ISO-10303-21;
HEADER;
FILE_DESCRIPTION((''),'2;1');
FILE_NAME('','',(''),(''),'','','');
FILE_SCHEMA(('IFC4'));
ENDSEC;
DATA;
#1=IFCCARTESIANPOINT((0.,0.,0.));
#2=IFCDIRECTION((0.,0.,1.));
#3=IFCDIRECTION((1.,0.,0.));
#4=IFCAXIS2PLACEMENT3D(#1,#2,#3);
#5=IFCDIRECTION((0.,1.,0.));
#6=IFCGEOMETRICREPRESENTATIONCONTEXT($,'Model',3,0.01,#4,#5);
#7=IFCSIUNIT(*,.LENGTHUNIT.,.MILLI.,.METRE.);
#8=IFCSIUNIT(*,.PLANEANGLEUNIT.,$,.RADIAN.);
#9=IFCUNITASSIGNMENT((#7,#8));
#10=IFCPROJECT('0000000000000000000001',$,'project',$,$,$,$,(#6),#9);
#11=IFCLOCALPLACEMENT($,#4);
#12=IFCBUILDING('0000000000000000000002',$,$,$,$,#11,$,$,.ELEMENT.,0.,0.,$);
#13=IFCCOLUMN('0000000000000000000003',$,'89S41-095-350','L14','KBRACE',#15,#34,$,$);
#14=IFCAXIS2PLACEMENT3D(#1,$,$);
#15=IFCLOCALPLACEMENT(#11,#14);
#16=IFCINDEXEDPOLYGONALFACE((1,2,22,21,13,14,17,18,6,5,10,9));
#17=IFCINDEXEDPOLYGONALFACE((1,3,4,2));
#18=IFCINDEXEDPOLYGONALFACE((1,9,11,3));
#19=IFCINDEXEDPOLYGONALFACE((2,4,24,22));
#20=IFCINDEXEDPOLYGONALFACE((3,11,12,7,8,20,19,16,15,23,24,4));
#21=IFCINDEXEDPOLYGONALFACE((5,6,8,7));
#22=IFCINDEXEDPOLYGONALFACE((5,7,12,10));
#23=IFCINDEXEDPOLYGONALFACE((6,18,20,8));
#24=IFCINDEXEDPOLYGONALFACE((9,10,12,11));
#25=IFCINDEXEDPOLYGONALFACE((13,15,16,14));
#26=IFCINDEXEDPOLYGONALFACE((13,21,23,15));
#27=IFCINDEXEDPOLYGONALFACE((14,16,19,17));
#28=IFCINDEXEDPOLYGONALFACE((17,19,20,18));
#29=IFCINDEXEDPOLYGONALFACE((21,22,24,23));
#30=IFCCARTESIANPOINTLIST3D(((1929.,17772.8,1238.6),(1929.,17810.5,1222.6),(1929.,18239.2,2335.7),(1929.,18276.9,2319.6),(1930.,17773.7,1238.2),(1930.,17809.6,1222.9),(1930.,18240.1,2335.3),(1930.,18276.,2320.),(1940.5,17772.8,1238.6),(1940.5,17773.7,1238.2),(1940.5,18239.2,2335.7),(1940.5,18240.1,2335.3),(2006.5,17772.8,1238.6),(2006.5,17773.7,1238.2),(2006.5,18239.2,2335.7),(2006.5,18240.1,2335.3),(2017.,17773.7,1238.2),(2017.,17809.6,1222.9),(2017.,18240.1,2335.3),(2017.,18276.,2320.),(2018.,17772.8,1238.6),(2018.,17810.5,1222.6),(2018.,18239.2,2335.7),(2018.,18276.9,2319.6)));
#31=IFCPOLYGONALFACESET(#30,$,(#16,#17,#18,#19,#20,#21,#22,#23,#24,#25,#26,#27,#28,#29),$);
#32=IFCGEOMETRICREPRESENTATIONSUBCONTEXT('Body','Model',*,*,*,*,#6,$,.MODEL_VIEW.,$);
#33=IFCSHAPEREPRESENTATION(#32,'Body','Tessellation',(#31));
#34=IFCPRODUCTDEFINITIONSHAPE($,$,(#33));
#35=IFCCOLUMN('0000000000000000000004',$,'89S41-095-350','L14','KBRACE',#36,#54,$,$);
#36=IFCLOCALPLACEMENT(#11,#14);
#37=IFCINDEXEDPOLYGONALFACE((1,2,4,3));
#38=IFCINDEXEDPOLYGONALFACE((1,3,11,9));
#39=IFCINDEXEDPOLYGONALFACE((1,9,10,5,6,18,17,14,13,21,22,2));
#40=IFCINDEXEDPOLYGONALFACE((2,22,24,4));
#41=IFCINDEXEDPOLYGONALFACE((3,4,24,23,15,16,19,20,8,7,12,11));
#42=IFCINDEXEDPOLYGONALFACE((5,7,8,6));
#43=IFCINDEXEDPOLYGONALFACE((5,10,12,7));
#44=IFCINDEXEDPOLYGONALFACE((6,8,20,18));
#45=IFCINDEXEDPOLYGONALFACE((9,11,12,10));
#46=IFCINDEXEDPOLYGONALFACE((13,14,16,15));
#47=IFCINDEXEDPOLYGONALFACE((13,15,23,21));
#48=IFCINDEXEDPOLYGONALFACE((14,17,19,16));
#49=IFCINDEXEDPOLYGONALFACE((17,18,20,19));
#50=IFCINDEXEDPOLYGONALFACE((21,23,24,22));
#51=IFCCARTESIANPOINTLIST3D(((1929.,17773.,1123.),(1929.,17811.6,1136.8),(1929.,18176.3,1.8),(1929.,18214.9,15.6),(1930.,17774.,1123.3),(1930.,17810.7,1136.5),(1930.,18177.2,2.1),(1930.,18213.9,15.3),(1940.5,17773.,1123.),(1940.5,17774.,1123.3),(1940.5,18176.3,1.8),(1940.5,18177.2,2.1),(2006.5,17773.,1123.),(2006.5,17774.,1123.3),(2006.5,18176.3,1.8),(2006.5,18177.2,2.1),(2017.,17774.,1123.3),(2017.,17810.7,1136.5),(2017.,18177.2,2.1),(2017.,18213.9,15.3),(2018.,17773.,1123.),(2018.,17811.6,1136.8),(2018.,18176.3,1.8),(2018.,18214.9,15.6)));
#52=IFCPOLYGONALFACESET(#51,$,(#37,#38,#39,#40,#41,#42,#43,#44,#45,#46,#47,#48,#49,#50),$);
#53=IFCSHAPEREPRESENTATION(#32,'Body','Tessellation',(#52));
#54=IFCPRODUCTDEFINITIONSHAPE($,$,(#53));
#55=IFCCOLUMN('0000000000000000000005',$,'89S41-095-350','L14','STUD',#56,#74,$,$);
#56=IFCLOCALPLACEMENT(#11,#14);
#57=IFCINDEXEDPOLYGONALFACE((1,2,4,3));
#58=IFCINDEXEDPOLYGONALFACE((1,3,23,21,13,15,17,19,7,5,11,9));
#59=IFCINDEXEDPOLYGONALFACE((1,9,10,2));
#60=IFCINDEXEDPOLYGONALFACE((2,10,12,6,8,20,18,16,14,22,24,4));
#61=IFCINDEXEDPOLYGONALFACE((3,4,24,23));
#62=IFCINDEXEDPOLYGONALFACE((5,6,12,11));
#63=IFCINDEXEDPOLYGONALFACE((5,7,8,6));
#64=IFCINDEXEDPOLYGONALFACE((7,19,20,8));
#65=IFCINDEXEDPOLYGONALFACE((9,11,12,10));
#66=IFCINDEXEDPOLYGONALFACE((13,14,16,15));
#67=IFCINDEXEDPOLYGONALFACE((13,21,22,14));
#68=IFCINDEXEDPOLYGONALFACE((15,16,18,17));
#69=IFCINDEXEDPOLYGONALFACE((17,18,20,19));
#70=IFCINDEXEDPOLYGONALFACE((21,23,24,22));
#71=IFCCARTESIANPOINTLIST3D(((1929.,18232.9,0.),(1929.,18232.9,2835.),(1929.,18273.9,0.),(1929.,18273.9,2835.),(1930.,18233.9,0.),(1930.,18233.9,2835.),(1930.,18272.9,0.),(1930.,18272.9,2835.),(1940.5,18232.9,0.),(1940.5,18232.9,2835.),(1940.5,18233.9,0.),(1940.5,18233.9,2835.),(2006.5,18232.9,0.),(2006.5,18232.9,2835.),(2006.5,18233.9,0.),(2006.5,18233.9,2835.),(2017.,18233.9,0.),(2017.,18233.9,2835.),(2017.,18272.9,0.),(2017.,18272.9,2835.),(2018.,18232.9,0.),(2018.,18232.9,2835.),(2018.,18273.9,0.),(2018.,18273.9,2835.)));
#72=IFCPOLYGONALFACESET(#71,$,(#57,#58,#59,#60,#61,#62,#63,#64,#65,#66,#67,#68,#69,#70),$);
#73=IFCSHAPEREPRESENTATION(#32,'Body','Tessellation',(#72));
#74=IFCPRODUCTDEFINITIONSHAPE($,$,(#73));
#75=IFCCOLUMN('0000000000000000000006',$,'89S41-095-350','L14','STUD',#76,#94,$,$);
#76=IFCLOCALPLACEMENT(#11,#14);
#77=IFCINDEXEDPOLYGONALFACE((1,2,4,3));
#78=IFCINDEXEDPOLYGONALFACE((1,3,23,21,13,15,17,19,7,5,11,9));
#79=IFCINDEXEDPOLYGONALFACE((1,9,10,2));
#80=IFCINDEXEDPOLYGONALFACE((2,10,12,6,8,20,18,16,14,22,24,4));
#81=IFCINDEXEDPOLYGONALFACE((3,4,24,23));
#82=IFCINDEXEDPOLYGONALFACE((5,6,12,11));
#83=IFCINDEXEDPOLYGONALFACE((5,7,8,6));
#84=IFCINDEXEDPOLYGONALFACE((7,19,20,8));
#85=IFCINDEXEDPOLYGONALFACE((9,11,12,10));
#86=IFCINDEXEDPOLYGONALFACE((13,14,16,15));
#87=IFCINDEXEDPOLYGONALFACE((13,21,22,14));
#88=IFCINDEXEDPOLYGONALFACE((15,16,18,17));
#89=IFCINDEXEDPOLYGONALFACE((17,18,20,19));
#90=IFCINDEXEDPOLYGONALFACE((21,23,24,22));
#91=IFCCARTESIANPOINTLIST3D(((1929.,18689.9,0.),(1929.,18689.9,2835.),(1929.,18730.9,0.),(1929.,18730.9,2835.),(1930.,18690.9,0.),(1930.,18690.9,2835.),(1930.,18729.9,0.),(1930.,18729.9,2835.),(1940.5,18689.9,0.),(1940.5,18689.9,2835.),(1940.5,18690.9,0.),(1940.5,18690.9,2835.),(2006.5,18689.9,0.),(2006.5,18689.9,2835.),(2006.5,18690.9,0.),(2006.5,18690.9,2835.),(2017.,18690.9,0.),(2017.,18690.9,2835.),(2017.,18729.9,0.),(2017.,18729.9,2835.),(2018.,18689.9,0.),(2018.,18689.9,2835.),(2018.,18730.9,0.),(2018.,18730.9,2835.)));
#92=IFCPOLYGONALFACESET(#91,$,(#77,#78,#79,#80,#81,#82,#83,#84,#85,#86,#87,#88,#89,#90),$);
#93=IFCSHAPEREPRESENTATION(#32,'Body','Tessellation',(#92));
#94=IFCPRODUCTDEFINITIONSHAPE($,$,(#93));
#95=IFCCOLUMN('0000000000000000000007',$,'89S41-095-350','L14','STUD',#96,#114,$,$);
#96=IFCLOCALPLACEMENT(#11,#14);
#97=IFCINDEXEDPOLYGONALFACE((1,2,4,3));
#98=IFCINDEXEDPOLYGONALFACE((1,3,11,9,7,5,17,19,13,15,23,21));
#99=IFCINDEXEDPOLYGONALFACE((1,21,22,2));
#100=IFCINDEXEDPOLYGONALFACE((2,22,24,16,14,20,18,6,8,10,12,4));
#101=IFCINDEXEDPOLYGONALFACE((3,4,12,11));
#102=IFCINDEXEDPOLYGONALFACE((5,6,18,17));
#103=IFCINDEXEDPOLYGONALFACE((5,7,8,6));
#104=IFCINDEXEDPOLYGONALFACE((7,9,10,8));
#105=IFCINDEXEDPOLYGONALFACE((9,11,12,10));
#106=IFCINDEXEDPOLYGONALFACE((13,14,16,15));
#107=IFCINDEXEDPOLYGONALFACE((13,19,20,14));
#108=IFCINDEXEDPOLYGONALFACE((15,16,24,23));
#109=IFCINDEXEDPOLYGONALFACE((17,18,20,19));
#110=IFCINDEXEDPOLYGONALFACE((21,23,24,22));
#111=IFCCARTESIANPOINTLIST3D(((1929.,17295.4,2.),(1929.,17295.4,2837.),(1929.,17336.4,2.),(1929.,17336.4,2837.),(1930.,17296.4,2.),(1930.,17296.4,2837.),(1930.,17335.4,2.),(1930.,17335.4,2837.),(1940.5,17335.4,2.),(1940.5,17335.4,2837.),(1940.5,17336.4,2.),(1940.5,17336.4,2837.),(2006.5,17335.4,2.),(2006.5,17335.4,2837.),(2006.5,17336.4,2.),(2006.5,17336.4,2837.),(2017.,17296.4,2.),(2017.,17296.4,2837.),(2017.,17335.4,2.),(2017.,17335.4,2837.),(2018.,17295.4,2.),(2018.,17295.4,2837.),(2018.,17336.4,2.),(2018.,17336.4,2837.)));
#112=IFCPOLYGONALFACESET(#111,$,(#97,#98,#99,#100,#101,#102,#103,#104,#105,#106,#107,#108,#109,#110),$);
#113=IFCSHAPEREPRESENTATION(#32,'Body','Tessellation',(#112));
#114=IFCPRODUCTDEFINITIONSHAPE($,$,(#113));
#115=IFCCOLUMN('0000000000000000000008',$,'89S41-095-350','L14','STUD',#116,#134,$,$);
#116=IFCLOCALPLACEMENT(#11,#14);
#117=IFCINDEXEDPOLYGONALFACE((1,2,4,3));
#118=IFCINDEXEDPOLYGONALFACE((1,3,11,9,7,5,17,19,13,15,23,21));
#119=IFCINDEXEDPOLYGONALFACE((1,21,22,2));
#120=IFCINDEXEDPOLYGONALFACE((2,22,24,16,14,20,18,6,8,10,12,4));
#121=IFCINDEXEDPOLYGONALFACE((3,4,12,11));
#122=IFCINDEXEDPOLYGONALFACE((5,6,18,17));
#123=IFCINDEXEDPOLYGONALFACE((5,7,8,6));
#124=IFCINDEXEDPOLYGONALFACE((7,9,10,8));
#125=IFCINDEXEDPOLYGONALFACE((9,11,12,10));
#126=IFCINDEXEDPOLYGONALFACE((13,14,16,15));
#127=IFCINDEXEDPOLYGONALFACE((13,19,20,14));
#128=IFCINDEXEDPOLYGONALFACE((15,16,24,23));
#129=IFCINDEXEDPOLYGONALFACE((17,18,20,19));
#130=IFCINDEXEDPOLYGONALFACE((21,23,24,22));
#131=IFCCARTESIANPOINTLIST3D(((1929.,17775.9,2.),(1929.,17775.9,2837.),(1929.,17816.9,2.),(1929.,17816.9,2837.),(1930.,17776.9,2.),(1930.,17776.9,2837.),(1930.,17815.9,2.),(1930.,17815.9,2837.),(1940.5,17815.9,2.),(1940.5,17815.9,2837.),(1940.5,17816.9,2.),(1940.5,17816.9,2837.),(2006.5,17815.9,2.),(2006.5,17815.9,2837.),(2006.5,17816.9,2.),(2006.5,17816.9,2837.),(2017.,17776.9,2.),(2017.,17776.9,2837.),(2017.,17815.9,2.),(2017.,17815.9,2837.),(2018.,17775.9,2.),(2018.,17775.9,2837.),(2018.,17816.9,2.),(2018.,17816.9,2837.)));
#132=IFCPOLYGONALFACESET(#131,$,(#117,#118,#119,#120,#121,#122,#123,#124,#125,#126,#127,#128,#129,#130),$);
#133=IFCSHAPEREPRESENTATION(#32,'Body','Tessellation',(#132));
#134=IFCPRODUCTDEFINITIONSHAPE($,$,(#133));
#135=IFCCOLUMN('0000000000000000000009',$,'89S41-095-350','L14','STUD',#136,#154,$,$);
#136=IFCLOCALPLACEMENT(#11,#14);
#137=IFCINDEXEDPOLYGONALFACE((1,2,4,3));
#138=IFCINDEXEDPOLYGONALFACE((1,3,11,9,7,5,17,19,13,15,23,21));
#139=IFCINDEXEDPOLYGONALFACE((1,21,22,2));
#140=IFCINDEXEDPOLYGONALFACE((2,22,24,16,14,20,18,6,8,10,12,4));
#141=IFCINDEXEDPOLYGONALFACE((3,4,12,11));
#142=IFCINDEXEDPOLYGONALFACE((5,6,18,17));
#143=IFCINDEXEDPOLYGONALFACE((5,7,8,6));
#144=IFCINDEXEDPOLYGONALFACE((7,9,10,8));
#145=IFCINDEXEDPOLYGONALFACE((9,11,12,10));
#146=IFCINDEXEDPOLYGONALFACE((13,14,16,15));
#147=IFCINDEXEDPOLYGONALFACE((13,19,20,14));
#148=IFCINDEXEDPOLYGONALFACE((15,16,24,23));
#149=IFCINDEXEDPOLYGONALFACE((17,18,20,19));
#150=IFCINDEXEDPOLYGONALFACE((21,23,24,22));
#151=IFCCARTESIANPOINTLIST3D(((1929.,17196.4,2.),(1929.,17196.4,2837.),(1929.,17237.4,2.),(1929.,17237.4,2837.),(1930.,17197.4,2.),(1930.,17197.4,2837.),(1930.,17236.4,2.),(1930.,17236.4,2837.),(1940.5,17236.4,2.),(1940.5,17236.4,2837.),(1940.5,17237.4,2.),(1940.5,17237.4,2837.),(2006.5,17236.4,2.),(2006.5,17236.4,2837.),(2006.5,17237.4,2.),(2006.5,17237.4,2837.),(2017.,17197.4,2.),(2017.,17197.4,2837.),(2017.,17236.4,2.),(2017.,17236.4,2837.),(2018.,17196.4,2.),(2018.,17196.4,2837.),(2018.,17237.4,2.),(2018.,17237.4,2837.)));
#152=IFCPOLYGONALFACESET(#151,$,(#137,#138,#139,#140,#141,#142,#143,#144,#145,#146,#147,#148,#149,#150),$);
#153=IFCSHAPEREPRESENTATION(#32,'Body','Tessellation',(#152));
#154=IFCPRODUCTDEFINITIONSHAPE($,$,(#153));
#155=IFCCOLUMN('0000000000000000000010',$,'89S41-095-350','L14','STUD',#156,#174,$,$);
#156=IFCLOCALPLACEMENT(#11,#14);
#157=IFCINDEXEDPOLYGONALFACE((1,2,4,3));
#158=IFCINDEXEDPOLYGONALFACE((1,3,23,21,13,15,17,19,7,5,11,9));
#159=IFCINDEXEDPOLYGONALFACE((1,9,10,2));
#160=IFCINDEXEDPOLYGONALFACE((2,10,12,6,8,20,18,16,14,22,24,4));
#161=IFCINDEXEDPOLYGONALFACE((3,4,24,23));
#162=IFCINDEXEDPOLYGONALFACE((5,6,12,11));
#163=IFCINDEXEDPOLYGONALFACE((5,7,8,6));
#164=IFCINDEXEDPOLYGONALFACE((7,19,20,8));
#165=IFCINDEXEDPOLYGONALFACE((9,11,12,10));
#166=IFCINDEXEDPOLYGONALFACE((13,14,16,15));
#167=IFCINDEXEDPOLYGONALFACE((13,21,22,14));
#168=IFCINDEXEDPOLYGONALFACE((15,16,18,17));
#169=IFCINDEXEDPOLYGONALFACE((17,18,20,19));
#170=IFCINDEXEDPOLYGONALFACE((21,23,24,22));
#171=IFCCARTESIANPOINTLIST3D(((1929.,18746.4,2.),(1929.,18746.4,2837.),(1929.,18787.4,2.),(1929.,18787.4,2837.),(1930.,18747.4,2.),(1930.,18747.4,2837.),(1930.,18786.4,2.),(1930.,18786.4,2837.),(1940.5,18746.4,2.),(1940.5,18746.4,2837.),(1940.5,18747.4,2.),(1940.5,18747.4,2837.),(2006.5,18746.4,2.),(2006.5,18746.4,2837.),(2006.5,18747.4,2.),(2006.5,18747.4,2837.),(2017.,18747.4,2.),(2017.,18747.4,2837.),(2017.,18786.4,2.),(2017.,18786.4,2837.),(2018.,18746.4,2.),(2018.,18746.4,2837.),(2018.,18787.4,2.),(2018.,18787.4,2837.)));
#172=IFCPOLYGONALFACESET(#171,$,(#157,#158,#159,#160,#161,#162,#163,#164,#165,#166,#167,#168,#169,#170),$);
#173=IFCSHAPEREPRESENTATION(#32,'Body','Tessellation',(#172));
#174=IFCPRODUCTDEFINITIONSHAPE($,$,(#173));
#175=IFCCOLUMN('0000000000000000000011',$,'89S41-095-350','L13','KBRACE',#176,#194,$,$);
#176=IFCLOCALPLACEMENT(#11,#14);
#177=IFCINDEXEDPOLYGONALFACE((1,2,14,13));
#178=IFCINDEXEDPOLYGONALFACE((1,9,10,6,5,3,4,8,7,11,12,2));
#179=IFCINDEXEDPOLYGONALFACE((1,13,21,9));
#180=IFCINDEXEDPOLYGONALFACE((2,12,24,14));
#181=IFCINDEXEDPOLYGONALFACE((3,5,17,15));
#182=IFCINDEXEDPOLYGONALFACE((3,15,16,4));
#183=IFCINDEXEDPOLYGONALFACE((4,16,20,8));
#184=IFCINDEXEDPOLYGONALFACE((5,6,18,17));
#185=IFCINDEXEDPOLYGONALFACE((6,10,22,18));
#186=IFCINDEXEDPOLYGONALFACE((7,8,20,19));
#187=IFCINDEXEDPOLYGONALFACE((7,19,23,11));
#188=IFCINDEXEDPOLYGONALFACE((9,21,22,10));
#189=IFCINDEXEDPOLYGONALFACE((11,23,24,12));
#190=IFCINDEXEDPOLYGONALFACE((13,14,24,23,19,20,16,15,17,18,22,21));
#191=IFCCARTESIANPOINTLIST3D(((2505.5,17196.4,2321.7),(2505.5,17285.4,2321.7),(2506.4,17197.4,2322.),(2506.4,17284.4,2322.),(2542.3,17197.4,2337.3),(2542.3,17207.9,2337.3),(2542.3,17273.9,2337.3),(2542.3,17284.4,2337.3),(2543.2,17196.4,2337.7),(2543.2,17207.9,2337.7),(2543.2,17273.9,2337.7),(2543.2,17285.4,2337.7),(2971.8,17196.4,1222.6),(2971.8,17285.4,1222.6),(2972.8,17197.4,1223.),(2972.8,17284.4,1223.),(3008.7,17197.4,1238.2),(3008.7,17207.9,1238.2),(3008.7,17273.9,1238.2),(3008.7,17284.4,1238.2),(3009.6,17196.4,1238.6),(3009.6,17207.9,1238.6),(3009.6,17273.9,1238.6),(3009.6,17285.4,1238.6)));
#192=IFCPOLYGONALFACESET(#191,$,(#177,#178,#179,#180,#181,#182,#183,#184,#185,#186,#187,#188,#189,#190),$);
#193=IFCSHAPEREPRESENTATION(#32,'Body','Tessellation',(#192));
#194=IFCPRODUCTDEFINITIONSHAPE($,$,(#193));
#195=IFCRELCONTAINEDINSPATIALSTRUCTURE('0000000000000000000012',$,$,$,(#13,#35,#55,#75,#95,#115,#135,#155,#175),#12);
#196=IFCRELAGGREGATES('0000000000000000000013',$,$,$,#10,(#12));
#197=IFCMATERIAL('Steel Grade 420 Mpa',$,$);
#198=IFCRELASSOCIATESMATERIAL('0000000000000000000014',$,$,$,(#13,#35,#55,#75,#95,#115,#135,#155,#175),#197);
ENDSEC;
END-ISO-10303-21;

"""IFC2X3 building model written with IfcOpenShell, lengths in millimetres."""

from ifc_helpers import new_model, si_unit, direction, frame, origin, origin_with_axes, origin_2d_with_axis, place, context, subcontext, project, spatial, c_section, extrude, source, transform, mapped, material, element, save


model = new_model("IFC2X3")

# Units and contexts
model_context = context("Model", 3, precision=0.01, world=origin_with_axes(), true_north=direction((0.0, 1.0, 0.0)))
body_context = subcontext(model_context, "Body", "Model", "MODEL_VIEW")
ifc_project = project(units=[si_unit("LENGTHUNIT", "METRE", prefix="MILLI"), si_unit("PLANEANGLEUNIT", "RADIAN")], contexts=[model_context])

# Building
building_placement = place(None, origin_with_axes())
building = spatial("IfcBuilding", under=ifc_project, at=building_placement, CompositionType="ELEMENT", ElevationOfRefHeight=0.0, ElevationOfTerrain=0.0)

# Columns
ifc_material_1 = material(Name="Steel Grade 420 Mpa")
shared_shape_1 = source(origin(), body_context, "Body", "SweptSolid", [
    extrude(c_section(Depth=89.0, Width=41.0, WallThickness=1.0, Girth=11.5, at=origin_2d_with_axis()), origin_with_axes(), (0.0, 0.0, 1.0), 1192.1),
])
column_1_placement = place(None, frame((1973.5, 17791.7, 1230.6), z_axis=(0.0, 0.391231, 0.920292), x_axis=(0.0, -0.920292, 0.391231)))
element("IfcColumn", 1, at=column_1_placement, inside=building, material=ifc_material_1, Name="89S41-095-350", Description="L14", ObjectType="KBRACE", context=body_context, shape_type="MappedRepresentation", body=[
    mapped(shared_shape_1, transform((0.0, 0.0, 0.0), scale=1.0)),
])
shared_shape_2 = source(origin(), body_context, "Body", "SweptSolid", [
    extrude(c_section(Depth=89.0, Width=41.0, WallThickness=1.0, Girth=11.5, at=origin_2d_with_axis()), origin_with_axes(), (0.0, 0.0, 1.0), 1191.5),
])
column_2_placement = place(None, frame((1973.5, 18195.6, 8.7), z_axis=(0.0, -0.338445, 0.940986), x_axis=(0.0, -0.940986, -0.338445)))
element("IfcColumn", 2, at=column_2_placement, inside=building, material=ifc_material_1, Name="89S41-095-350", Description="L14", ObjectType="KBRACE", context=body_context, shape_type="MappedRepresentation", body=[
    mapped(shared_shape_2, transform((0.0, 0.0, 0.0), scale=1.0)),
])
shared_shape_3 = source(origin(), body_context, "Body", "SweptSolid", [
    extrude(c_section(Depth=89.0, Width=41.0, WallThickness=1.0, Girth=11.5, at=origin_2d_with_axis()), origin_with_axes(), (0.0, 0.0, 1.0), 2835.0),
])
column_3_placement = place(None, frame((1973.5, 18253.4, 0.0), z_axis=(0.0, 0.0, 1.0), x_axis=(0.0, -1.0, 0.0)))
element("IfcColumn", 3, at=column_3_placement, inside=building, material=ifc_material_1, Name="89S41-095-350", Description="L14", ObjectType="STUD", context=body_context, shape_type="MappedRepresentation", body=[
    mapped(shared_shape_3, transform((0.0, 0.0, 0.0), scale=1.0)),
])
shared_shape_4 = source(origin(), body_context, "Body", "SweptSolid", [
    extrude(c_section(Depth=89.0, Width=41.0, WallThickness=1.0, Girth=11.5, at=origin_2d_with_axis()), origin_with_axes(), (0.0, 0.0, 1.0), 2835.0),
])
column_4_placement = place(None, frame((1973.5, 18710.4, 0.0), z_axis=(0.0, 0.0, 1.0), x_axis=(0.0, -1.0, 0.0)))
element("IfcColumn", 4, at=column_4_placement, inside=building, material=ifc_material_1, Name="89S41-095-350", Description="L14", ObjectType="STUD", context=body_context, shape_type="MappedRepresentation", body=[
    mapped(shared_shape_4, transform((0.0, 0.0, 0.0), scale=1.0)),
])
shared_shape_5 = source(origin(), body_context, "Body", "SweptSolid", [
    extrude(c_section(Depth=89.0, Width=41.0, WallThickness=1.0, Girth=11.5, at=origin_2d_with_axis()), origin_with_axes(), (0.0, 0.0, 1.0), 2835.0),
])
column_5_placement = place(None, frame((1973.5, 17315.9, 2.0), z_axis=(0.0, 0.0, 1.0), x_axis=(0.0, 1.0, 0.0)))
element("IfcColumn", 5, at=column_5_placement, inside=building, material=ifc_material_1, Name="89S41-095-350", Description="L14", ObjectType="STUD", context=body_context, shape_type="MappedRepresentation", body=[
    mapped(shared_shape_5, transform((0.0, 0.0, 0.0), scale=1.0)),
])
shared_shape_6 = source(origin(), body_context, "Body", "SweptSolid", [
    extrude(c_section(Depth=89.0, Width=41.0, WallThickness=1.0, Girth=11.5, at=origin_2d_with_axis()), origin_with_axes(), (0.0, 0.0, 1.0), 2835.0),
])
column_6_placement = place(None, frame((1973.5, 17796.4, 2.0), z_axis=(0.0, 0.0, 1.0), x_axis=(0.0, 1.0, 0.0)))
element("IfcColumn", 6, at=column_6_placement, inside=building, material=ifc_material_1, Name="89S41-095-350", Description="L14", ObjectType="STUD", context=body_context, shape_type="MappedRepresentation", body=[
    mapped(shared_shape_6, transform((0.0, 0.0, 0.0), scale=1.0)),
])
shared_shape_7 = source(origin(), body_context, "Body", "SweptSolid", [
    extrude(c_section(Depth=89.0, Width=41.0, WallThickness=1.0, Girth=11.5, at=origin_2d_with_axis()), origin_with_axes(), (0.0, 0.0, 1.0), 2835.0),
])
column_7_placement = place(None, frame((1973.5, 17216.9, 2.0), z_axis=(0.0, 0.0, 1.0), x_axis=(0.0, 1.0, 0.0)))
element("IfcColumn", 7, at=column_7_placement, inside=building, material=ifc_material_1, Name="89S41-095-350", Description="L14", ObjectType="STUD", context=body_context, shape_type="MappedRepresentation", body=[
    mapped(shared_shape_7, transform((0.0, 0.0, 0.0), scale=1.0)),
])
shared_shape_8 = source(origin(), body_context, "Body", "SweptSolid", [
    extrude(c_section(Depth=89.0, Width=41.0, WallThickness=1.0, Girth=11.5, at=origin_2d_with_axis()), origin_with_axes(), (0.0, 0.0, 1.0), 2835.0),
])
column_8_placement = place(None, frame((1973.5, 18766.9, 2.0), z_axis=(0.0, 0.0, 1.0), x_axis=(0.0, -1.0, 0.0)))
element("IfcColumn", 8, at=column_8_placement, inside=building, material=ifc_material_1, Name="89S41-095-350", Description="L14", ObjectType="STUD", context=body_context, shape_type="MappedRepresentation", body=[
    mapped(shared_shape_8, transform((0.0, 0.0, 0.0), scale=1.0)),
])
shared_shape_9 = source(origin(), body_context, "Body", "SweptSolid", [
    extrude(c_section(Depth=89.0, Width=41.0, WallThickness=1.0, Girth=11.5, at=origin_2d_with_axis()), origin_with_axes(), (0.0, 0.0, 1.0), 1193.9),
])
column_9_placement = place(None, frame((2990.7, 17240.9, 1230.6), z_axis=(-0.390616, 0.0, 0.920554), x_axis=(0.920554, 0.0, 0.390616)))
element("IfcColumn", 9, at=column_9_placement, inside=building, material=ifc_material_1, Name="89S41-095-350", Description="L13", ObjectType="KBRACE", context=body_context, shape_type="MappedRepresentation", body=[
    mapped(shared_shape_9, transform((0.0, 0.0, 0.0), scale=1.0)),
])

save(model, "model.ifc")
